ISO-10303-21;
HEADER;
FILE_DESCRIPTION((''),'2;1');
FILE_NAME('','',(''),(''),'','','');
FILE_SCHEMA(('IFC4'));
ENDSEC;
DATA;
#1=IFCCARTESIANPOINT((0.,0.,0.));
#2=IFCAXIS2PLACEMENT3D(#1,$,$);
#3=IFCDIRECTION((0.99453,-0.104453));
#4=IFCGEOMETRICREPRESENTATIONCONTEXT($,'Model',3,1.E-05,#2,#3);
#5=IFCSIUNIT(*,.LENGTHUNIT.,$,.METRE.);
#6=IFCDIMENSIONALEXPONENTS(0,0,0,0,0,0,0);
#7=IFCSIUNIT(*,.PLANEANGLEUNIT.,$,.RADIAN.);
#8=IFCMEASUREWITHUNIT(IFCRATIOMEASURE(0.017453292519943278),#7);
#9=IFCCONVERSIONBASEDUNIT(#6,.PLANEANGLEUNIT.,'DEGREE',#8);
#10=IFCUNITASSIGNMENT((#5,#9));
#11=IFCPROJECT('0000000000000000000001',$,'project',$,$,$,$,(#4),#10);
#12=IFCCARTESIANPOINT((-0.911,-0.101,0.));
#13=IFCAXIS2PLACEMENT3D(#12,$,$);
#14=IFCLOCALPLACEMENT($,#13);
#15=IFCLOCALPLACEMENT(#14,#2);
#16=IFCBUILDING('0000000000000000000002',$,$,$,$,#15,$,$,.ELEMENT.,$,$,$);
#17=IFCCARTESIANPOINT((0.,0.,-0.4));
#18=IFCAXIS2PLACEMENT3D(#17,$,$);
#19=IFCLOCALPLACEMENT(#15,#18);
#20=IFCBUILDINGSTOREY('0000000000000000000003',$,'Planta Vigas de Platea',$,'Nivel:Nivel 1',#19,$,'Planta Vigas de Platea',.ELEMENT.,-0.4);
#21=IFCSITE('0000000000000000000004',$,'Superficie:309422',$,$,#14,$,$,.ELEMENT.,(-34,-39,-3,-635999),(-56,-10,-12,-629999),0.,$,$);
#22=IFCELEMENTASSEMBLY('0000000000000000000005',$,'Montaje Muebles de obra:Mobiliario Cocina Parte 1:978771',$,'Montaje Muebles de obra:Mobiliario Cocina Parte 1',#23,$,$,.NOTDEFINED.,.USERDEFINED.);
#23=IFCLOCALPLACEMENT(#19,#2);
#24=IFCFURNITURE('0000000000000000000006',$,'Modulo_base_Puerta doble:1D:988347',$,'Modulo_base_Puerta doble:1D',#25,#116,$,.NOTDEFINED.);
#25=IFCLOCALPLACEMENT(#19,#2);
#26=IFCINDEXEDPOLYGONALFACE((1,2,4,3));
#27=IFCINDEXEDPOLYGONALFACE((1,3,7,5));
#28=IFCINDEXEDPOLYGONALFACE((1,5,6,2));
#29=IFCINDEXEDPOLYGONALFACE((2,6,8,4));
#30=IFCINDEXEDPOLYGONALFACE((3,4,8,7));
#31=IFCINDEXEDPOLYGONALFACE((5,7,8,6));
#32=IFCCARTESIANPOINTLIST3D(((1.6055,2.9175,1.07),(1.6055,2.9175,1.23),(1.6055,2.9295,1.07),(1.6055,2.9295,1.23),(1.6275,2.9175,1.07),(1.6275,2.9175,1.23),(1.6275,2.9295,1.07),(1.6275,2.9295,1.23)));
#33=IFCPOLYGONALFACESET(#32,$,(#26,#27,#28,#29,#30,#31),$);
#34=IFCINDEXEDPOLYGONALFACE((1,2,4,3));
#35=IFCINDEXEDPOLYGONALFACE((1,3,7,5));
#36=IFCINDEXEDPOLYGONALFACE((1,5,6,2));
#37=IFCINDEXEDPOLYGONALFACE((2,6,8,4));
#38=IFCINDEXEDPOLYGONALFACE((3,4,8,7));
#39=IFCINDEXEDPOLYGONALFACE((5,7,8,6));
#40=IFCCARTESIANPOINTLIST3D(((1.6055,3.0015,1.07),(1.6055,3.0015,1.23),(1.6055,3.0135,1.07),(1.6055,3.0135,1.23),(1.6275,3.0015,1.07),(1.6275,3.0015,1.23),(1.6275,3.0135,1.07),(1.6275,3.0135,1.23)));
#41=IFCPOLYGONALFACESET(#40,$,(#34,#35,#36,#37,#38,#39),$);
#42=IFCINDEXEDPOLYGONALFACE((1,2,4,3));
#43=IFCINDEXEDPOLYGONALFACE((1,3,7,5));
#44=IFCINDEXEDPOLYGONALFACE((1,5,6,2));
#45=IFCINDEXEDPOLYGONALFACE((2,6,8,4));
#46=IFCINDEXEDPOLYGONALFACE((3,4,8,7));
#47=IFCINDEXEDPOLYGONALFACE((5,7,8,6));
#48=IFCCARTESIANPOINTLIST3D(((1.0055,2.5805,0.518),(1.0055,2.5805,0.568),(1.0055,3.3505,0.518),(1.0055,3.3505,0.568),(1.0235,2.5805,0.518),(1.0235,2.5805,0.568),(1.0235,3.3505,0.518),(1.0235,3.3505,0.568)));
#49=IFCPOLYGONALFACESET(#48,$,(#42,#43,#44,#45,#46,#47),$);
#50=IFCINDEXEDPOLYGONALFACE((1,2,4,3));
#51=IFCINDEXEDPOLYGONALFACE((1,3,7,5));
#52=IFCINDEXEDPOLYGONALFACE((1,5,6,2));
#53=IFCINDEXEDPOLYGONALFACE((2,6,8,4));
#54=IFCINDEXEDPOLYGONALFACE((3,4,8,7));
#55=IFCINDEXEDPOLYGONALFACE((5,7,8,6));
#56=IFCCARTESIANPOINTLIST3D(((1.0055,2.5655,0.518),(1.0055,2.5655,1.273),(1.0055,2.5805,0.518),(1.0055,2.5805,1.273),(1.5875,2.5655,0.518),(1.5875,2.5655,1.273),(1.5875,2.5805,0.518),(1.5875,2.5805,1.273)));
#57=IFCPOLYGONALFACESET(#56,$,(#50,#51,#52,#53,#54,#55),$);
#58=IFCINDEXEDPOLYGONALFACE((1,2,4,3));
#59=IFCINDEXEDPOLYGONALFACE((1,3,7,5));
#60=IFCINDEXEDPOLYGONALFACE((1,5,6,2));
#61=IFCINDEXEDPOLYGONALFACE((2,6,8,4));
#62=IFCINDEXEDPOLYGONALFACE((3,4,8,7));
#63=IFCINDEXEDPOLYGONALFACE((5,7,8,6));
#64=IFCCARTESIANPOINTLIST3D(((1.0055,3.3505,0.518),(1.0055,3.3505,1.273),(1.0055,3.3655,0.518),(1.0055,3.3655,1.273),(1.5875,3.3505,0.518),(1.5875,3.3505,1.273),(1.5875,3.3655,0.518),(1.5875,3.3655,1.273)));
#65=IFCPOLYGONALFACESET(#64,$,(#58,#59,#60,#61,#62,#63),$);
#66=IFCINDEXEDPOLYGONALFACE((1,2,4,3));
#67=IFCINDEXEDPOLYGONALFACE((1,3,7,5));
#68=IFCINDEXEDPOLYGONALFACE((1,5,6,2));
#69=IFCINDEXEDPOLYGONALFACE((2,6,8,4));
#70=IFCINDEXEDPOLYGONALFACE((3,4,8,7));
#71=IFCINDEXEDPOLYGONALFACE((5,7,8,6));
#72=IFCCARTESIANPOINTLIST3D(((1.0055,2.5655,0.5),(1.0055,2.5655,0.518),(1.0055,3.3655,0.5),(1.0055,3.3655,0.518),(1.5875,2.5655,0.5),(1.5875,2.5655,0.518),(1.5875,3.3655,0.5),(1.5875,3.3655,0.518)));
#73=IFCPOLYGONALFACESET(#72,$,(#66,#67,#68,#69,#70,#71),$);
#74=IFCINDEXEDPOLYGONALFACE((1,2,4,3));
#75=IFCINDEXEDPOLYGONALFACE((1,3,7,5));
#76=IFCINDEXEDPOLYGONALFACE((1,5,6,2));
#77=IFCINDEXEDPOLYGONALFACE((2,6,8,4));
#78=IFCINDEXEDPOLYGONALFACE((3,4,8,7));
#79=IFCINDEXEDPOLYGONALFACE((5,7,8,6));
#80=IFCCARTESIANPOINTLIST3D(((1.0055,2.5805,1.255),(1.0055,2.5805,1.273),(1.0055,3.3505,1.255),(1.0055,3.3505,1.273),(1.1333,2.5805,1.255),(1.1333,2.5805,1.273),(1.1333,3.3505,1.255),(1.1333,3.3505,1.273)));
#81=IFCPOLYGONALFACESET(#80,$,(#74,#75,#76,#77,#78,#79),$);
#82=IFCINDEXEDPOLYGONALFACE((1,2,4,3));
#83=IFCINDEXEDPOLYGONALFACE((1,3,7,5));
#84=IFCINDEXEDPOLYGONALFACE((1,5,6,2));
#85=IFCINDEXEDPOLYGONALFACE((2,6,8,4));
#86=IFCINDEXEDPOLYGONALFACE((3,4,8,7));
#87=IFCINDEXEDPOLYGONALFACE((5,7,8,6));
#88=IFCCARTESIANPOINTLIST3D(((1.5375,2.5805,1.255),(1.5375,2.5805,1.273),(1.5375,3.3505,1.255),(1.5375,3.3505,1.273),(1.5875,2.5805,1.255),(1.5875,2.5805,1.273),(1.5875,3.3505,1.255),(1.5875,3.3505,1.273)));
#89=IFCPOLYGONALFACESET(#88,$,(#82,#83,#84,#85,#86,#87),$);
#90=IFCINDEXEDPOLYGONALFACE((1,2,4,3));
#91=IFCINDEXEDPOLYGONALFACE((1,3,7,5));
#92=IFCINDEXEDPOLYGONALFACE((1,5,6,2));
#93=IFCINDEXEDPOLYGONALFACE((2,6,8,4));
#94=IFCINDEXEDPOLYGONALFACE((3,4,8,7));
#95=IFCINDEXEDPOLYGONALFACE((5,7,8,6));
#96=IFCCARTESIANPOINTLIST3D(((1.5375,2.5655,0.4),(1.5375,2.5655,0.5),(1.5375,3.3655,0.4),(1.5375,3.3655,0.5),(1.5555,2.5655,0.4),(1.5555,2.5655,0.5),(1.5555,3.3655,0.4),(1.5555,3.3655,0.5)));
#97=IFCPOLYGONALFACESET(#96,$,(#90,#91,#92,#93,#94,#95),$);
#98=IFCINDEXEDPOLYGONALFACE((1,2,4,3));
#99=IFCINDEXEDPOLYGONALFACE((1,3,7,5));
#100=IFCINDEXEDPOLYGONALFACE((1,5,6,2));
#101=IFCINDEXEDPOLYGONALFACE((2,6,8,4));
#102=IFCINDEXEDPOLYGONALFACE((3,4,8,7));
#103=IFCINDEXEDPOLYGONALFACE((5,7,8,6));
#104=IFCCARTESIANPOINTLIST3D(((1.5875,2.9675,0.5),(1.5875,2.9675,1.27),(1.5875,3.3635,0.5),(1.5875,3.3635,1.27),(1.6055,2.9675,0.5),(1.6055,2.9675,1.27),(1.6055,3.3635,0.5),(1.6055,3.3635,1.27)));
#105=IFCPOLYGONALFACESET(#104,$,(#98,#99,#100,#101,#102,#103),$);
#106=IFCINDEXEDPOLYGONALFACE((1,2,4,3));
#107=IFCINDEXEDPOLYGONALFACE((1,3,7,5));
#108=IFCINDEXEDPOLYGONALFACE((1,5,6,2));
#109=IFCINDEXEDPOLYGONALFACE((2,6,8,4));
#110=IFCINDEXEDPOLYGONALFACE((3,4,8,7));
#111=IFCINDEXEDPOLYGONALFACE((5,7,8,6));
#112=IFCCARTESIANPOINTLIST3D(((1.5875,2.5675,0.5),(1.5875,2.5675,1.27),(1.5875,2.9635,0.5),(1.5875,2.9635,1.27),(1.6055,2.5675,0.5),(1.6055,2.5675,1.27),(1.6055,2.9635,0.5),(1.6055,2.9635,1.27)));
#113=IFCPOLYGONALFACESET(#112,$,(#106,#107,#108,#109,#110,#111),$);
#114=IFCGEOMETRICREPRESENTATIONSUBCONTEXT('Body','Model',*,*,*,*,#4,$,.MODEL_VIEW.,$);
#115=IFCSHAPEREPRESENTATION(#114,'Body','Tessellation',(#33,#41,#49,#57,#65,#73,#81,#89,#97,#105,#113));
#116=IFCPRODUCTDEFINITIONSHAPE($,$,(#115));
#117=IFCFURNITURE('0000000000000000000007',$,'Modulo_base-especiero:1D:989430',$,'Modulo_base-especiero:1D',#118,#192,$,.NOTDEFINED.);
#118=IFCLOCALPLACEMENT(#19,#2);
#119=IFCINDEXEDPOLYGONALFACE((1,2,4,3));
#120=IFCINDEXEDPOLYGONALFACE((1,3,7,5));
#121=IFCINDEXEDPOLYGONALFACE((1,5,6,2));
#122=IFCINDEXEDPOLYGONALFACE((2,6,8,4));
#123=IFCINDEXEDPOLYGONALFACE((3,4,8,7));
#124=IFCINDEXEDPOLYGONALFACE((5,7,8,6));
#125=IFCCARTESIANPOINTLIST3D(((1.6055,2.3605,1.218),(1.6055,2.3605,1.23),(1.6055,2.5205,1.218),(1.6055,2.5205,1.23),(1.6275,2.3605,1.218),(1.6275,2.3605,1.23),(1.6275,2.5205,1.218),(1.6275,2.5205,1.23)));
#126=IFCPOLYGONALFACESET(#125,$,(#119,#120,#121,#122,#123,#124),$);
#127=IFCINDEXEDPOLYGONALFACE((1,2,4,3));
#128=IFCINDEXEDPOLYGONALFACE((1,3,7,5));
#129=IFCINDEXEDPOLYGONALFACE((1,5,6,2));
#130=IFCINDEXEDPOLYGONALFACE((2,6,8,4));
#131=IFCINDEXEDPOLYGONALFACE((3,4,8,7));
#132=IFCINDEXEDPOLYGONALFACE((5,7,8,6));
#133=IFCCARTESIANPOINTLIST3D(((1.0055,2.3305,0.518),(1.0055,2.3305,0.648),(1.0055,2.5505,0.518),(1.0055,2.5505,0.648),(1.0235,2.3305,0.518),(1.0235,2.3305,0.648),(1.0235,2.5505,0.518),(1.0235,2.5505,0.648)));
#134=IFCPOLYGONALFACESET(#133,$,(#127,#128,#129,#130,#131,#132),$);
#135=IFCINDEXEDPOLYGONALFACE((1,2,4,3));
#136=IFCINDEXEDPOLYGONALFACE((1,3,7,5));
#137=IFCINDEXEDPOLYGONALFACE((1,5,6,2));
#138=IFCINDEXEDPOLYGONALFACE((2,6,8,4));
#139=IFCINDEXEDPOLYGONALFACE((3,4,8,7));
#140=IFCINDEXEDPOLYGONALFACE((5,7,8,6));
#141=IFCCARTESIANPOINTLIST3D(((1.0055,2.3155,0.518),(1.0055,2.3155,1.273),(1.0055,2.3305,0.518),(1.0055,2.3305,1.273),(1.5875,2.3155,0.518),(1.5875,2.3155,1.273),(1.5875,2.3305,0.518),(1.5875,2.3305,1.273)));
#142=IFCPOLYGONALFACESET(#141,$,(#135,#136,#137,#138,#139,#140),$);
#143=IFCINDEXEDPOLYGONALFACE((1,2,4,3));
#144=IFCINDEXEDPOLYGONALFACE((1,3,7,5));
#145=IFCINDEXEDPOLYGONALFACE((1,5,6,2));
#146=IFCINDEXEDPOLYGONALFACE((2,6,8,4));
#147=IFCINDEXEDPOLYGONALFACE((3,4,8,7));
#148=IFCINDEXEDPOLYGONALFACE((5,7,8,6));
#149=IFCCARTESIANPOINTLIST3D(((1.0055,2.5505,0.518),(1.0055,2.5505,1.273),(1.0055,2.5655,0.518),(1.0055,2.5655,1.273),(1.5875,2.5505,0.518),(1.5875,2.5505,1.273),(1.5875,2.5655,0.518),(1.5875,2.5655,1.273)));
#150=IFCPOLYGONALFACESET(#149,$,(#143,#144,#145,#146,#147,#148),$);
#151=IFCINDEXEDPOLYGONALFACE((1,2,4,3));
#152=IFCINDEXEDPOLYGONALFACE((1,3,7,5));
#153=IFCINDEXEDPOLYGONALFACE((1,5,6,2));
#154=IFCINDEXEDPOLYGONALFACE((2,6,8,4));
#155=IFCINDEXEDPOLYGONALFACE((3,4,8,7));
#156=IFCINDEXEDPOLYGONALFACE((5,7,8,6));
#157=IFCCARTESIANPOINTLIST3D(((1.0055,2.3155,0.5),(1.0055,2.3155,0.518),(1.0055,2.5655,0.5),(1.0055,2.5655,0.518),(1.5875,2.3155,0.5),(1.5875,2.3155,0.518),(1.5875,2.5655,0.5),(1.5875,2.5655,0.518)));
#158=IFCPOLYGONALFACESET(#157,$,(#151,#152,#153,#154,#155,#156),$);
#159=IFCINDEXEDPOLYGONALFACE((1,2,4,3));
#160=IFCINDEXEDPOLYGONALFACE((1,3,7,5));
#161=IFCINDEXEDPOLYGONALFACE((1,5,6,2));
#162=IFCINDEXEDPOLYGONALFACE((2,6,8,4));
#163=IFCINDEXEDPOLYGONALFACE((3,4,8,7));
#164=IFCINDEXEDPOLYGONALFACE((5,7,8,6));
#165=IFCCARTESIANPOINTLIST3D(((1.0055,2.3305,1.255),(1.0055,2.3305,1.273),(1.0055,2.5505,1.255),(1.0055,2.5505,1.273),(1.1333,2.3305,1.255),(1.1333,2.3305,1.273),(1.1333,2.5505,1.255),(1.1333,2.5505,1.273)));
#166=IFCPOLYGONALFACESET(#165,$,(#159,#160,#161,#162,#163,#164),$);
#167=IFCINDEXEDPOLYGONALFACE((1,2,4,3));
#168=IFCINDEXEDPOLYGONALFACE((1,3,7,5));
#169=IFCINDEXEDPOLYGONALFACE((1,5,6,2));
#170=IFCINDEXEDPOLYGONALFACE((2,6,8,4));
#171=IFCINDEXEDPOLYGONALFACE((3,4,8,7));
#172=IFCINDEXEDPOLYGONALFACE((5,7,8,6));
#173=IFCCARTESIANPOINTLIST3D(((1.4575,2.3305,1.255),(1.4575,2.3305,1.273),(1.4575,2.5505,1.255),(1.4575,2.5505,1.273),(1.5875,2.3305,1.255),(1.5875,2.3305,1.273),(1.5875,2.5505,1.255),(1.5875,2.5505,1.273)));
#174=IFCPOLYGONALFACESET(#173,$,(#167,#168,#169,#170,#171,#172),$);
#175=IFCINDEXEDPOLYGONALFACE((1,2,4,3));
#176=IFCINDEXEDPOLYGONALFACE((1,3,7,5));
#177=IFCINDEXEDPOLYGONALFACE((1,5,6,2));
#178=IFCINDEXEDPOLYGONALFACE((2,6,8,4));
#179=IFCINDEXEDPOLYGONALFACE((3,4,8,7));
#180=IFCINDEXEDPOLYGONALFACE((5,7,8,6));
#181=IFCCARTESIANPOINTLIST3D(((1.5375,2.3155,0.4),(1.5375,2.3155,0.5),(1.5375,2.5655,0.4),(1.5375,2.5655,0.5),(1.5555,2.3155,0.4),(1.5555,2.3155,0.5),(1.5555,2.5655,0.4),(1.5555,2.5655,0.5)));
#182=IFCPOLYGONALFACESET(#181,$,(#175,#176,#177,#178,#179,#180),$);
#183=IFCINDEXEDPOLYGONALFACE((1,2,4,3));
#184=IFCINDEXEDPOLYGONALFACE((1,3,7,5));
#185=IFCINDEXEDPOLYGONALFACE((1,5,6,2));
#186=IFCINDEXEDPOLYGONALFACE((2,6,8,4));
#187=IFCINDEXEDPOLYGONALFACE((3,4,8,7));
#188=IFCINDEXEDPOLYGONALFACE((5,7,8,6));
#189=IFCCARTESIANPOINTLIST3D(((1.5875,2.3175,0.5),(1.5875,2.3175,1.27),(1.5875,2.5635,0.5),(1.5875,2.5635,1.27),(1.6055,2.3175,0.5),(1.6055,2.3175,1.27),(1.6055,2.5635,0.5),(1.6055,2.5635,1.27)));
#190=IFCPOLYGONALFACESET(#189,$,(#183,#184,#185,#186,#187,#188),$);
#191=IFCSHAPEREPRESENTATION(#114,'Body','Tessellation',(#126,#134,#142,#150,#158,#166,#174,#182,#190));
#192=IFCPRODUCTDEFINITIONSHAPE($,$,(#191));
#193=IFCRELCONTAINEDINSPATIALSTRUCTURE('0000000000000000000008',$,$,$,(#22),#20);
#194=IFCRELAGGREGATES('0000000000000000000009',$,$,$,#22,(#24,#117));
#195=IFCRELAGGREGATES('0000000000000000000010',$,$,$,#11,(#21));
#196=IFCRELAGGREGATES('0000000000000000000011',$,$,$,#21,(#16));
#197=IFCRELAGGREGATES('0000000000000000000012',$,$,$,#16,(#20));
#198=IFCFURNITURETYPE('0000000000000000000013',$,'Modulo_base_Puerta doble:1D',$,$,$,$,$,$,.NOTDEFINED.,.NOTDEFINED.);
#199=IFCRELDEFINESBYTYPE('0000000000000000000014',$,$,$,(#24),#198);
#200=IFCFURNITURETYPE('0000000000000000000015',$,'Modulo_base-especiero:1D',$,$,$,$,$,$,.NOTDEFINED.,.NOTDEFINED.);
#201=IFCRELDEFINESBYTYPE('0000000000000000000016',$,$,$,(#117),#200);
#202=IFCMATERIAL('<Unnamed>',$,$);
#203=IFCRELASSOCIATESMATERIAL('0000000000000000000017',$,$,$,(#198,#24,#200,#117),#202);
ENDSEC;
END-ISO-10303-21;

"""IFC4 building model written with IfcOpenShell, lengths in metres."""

from ifc_helpers import new_model, entity, si_unit, converted_unit, direction, frame, frame_2d, origin, origin_2d_with_axis, place, context, subcontext, project, spatial, rectangle, extrude, source, transform, mapped, material, type_object, type_shapes, element, aggregate, save


model = new_model("IFC4")

# Units and contexts
model_context = context("Model", 3, precision=1e-05, world=origin(), true_north=direction((0.99453, -0.104453)))
body_context = subcontext(model_context, "Body", "Model", "MODEL_VIEW")
ifc_project = project(units=[si_unit("LENGTHUNIT", "METRE"), converted_unit("PLANEANGLEUNIT", "DEGREE", entity("IfcRatioMeasure", 0.017453292519943278), si_unit("PLANEANGLEUNIT", "RADIAN"), dimensions=[0, 0, 0, 0, 0, 0, 0])], contexts=[model_context])

# Site, building, storey
site_placement = place(None, frame((-0.911, -0.101, 0.0)))
site = spatial("IfcSite", under=ifc_project, at=site_placement, Name="Superficie:309422", CompositionType="ELEMENT", RefLatitude=(-34, -39, -3, -635999), RefLongitude=(-56, -10, -12, -629999), RefElevation=0.0)
building_placement = place(site_placement, origin())
building = spatial("IfcBuilding", under=site, at=building_placement, CompositionType="ELEMENT")
storey_placement = place(building_placement, frame((0.0, 0.0, -0.4)))
storey = spatial("IfcBuildingStorey", under=building, at=storey_placement, Name="Planta Vigas de Platea", ObjectType="Nivel:Nivel 1", LongName="Planta Vigas de Platea", CompositionType="ELEMENT", Elevation=-0.4)

# Shared definitions
ifc_material_1 = material(Name="<Unnamed>")

# Element assembly, furniture
assembly_placement = place(storey_placement, origin())
assembly = element("IfcElementAssembly", 1, at=assembly_placement, inside=storey, Name="Montaje Muebles de obra:Mobiliario Cocina Parte 1:978771", ObjectType="Montaje Muebles de obra:Mobiliario Cocina Parte 1", AssemblyPlace="NOTDEFINED", PredefinedType="USERDEFINED")
furniture_type_1 = type_object("IfcFurnitureType", Name="Modulo_base_Puerta doble:1D", AssemblyPlace="NOTDEFINED", PredefinedType="NOTDEFINED", material=ifc_material_1)
shared_shape_1 = source(origin(), body_context, "Body", "SweptSolid", [
    extrude(rectangle(XDim=0.022, YDim=0.012, at=origin_2d_with_axis()), frame((0.611, 0.358, 0.67), z_axis=(0.0, 0.0, 1.0), x_axis=(-1.0, 0.0, 0.0)), (0.0, 0.0, 1.0), 0.16),
    extrude(rectangle(XDim=0.022, YDim=0.012, at=frame_2d((0.0, 0.0), x_axis=(1.0, 0.0))), frame((0.611, 0.442, 0.67), z_axis=(0.0, 0.0, 1.0), x_axis=(-1.0, 0.0, 0.0)), (0.0, 0.0, 1.0), 0.16),
    extrude(rectangle(XDim=0.77, YDim=0.018, at=frame_2d((0.0, 0.0), x_axis=(1.0, 0.0))), frame((0.009, 0.4, 0.118), z_axis=(0.0, 0.0, 1.0), x_axis=(0.0, -1.0, 0.0)), (0.0, 0.0, 1.0), 0.05),
    extrude(rectangle(XDim=0.015, YDim=0.582, at=frame_2d((0.0, 0.0), x_axis=(1.0, 0.0))), frame((0.291, 0.0075, 0.118), z_axis=(0.0, 0.0, 1.0), x_axis=(0.0, -1.0, 0.0)), (0.0, 0.0, 1.0), 0.755),
    extrude(rectangle(XDim=0.015, YDim=0.582, at=frame_2d((0.0, 0.0), x_axis=(1.0, 0.0))), frame((0.291, 0.7925, 0.118), z_axis=(0.0, 0.0, 1.0), x_axis=(0.0, 1.0, 0.0)), (0.0, 0.0, 1.0), 0.755),
    extrude(rectangle(XDim=0.8, YDim=0.582, at=frame_2d((0.0, 0.0), x_axis=(1.0, 0.0))), frame((0.291, 0.4, 0.1), z_axis=(0.0, 0.0, 1.0), x_axis=(0.0, -1.0, 0.0)), (0.0, 0.0, 1.0), 0.018),
    extrude(rectangle(XDim=0.77, YDim=0.1278, at=frame_2d((0.0, 0.0), x_axis=(1.0, 0.0))), frame((0.0639, 0.4, 0.855), z_axis=(0.0, 0.0, 1.0), x_axis=(0.0, -1.0, 0.0)), (0.0, 0.0, 1.0), 0.018),
    extrude(rectangle(XDim=0.77, YDim=0.05, at=frame_2d((0.0, 0.0), x_axis=(1.0, 0.0))), frame((0.557, 0.4, 0.855), z_axis=(0.0, 0.0, 1.0), x_axis=(0.0, -1.0, 0.0)), (0.0, 0.0, 1.0), 0.018),
    extrude(rectangle(XDim=0.018, YDim=0.8, at=frame_2d((0.0, 0.0), x_axis=(1.0, 0.0))), frame((0.541, 0.4, 0.0)), (0.0, 0.0, 1.0), 0.1),
    extrude(rectangle(XDim=0.018, YDim=0.396, at=origin_2d_with_axis()), frame((0.591, 0.6, 0.1), z_axis=(0.0, 0.0, 1.0), x_axis=(-1.0, 0.0, 0.0)), (0.0, 0.0, 1.0), 0.77),
    extrude(rectangle(XDim=0.018, YDim=0.396, at=frame_2d((0.0, 0.0), x_axis=(1.0, 0.0))), frame((0.591, 0.2, 0.1), z_axis=(0.0, 0.0, 1.0), x_axis=(-1.0, 0.0, 0.0)), (0.0, 0.0, 1.0), 0.77),
])
type_shapes(furniture_type_1, [shared_shape_1])
furniture_1_placement = place(assembly_placement, frame((1.0055, 2.5655, 0.4)))
furniture_1 = element("IfcFurniture", 2, at=furniture_1_placement, type_object=furniture_type_1, material=ifc_material_1, Name="Modulo_base_Puerta doble:1D:988347", ObjectType="Modulo_base_Puerta doble:1D", PredefinedType="NOTDEFINED", context=body_context, shape_type="MappedRepresentation", body=[
    mapped(shared_shape_1, transform((0.0, 0.0, 0.0), scale=1.0)),
])
furniture_type_2 = type_object("IfcFurnitureType", Name="Modulo_base-especiero:1D", AssemblyPlace="NOTDEFINED", PredefinedType="NOTDEFINED", material=ifc_material_1)
shared_shape_2 = source(origin(), body_context, "Body", "SweptSolid", [
    extrude(rectangle(XDim=0.022, YDim=0.16, at=frame_2d((0.0, 0.0), x_axis=(1.0, 0.0))), frame((0.611, 0.125, 0.818), z_axis=(0.0, 0.0, 1.0), x_axis=(-1.0, 0.0, 0.0)), (0.0, 0.0, 1.0), 0.012),
    extrude(rectangle(XDim=0.22, YDim=0.018, at=frame_2d((0.0, 0.0), x_axis=(1.0, 0.0))), frame((0.009, 0.125, 0.118), z_axis=(0.0, 0.0, 1.0), x_axis=(0.0, -1.0, 0.0)), (0.0, 0.0, 1.0), 0.13),
    extrude(rectangle(XDim=0.015, YDim=0.582, at=origin_2d_with_axis()), frame((0.291, 0.0075, 0.118), z_axis=(0.0, 0.0, 1.0), x_axis=(0.0, -1.0, 0.0)), (0.0, 0.0, 1.0), 0.755),
    extrude(rectangle(XDim=0.015, YDim=0.582, at=frame_2d((0.0, 0.0), x_axis=(1.0, 0.0))), frame((0.291, 0.2425, 0.118), z_axis=(0.0, 0.0, 1.0), x_axis=(0.0, 1.0, 0.0)), (0.0, 0.0, 1.0), 0.755),
    extrude(rectangle(XDim=0.25, YDim=0.582, at=frame_2d((0.0, 0.0), x_axis=(1.0, 0.0))), frame((0.291, 0.125, 0.1), z_axis=(0.0, 0.0, 1.0), x_axis=(0.0, -1.0, 0.0)), (0.0, 0.0, 1.0), 0.018),
    extrude(rectangle(XDim=0.22, YDim=0.1278, at=frame_2d((0.0, 0.0), x_axis=(1.0, 0.0))), frame((0.0639, 0.125, 0.855), z_axis=(0.0, 0.0, 1.0), x_axis=(0.0, -1.0, 0.0)), (0.0, 0.0, 1.0), 0.018),
    extrude(rectangle(XDim=0.22, YDim=0.13, at=frame_2d((0.0, 0.0), x_axis=(1.0, 0.0))), frame((0.517, 0.125, 0.855), z_axis=(0.0, 0.0, 1.0), x_axis=(0.0, -1.0, 0.0)), (0.0, 0.0, 1.0), 0.018),
    extrude(rectangle(XDim=0.018, YDim=0.25, at=frame_2d((0.0, 0.0), x_axis=(1.0, 0.0))), frame((0.541, 0.125, 0.0)), (0.0, 0.0, 1.0), 0.1),
    extrude(rectangle(XDim=0.018, YDim=0.246, at=frame_2d((0.0, 0.0), x_axis=(1.0, 0.0))), frame((0.591, 0.125, 0.1), z_axis=(0.0, 0.0, 1.0), x_axis=(-1.0, 0.0, 0.0)), (0.0, 0.0, 1.0), 0.77),
])
type_shapes(furniture_type_2, [shared_shape_2])
furniture_2_placement = place(assembly_placement, frame((1.0055, 2.3155, 0.4)))
furniture_2 = element("IfcFurniture", 3, at=furniture_2_placement, type_object=furniture_type_2, material=ifc_material_1, Name="Modulo_base-especiero:1D:989430", ObjectType="Modulo_base-especiero:1D", PredefinedType="NOTDEFINED", context=body_context, shape_type="MappedRepresentation", body=[
    mapped(shared_shape_2, transform((0.0, 0.0, 0.0), scale=1.0)),
])
aggregate(assembly, [furniture_1, furniture_2])

save(model, "model.ifc")
